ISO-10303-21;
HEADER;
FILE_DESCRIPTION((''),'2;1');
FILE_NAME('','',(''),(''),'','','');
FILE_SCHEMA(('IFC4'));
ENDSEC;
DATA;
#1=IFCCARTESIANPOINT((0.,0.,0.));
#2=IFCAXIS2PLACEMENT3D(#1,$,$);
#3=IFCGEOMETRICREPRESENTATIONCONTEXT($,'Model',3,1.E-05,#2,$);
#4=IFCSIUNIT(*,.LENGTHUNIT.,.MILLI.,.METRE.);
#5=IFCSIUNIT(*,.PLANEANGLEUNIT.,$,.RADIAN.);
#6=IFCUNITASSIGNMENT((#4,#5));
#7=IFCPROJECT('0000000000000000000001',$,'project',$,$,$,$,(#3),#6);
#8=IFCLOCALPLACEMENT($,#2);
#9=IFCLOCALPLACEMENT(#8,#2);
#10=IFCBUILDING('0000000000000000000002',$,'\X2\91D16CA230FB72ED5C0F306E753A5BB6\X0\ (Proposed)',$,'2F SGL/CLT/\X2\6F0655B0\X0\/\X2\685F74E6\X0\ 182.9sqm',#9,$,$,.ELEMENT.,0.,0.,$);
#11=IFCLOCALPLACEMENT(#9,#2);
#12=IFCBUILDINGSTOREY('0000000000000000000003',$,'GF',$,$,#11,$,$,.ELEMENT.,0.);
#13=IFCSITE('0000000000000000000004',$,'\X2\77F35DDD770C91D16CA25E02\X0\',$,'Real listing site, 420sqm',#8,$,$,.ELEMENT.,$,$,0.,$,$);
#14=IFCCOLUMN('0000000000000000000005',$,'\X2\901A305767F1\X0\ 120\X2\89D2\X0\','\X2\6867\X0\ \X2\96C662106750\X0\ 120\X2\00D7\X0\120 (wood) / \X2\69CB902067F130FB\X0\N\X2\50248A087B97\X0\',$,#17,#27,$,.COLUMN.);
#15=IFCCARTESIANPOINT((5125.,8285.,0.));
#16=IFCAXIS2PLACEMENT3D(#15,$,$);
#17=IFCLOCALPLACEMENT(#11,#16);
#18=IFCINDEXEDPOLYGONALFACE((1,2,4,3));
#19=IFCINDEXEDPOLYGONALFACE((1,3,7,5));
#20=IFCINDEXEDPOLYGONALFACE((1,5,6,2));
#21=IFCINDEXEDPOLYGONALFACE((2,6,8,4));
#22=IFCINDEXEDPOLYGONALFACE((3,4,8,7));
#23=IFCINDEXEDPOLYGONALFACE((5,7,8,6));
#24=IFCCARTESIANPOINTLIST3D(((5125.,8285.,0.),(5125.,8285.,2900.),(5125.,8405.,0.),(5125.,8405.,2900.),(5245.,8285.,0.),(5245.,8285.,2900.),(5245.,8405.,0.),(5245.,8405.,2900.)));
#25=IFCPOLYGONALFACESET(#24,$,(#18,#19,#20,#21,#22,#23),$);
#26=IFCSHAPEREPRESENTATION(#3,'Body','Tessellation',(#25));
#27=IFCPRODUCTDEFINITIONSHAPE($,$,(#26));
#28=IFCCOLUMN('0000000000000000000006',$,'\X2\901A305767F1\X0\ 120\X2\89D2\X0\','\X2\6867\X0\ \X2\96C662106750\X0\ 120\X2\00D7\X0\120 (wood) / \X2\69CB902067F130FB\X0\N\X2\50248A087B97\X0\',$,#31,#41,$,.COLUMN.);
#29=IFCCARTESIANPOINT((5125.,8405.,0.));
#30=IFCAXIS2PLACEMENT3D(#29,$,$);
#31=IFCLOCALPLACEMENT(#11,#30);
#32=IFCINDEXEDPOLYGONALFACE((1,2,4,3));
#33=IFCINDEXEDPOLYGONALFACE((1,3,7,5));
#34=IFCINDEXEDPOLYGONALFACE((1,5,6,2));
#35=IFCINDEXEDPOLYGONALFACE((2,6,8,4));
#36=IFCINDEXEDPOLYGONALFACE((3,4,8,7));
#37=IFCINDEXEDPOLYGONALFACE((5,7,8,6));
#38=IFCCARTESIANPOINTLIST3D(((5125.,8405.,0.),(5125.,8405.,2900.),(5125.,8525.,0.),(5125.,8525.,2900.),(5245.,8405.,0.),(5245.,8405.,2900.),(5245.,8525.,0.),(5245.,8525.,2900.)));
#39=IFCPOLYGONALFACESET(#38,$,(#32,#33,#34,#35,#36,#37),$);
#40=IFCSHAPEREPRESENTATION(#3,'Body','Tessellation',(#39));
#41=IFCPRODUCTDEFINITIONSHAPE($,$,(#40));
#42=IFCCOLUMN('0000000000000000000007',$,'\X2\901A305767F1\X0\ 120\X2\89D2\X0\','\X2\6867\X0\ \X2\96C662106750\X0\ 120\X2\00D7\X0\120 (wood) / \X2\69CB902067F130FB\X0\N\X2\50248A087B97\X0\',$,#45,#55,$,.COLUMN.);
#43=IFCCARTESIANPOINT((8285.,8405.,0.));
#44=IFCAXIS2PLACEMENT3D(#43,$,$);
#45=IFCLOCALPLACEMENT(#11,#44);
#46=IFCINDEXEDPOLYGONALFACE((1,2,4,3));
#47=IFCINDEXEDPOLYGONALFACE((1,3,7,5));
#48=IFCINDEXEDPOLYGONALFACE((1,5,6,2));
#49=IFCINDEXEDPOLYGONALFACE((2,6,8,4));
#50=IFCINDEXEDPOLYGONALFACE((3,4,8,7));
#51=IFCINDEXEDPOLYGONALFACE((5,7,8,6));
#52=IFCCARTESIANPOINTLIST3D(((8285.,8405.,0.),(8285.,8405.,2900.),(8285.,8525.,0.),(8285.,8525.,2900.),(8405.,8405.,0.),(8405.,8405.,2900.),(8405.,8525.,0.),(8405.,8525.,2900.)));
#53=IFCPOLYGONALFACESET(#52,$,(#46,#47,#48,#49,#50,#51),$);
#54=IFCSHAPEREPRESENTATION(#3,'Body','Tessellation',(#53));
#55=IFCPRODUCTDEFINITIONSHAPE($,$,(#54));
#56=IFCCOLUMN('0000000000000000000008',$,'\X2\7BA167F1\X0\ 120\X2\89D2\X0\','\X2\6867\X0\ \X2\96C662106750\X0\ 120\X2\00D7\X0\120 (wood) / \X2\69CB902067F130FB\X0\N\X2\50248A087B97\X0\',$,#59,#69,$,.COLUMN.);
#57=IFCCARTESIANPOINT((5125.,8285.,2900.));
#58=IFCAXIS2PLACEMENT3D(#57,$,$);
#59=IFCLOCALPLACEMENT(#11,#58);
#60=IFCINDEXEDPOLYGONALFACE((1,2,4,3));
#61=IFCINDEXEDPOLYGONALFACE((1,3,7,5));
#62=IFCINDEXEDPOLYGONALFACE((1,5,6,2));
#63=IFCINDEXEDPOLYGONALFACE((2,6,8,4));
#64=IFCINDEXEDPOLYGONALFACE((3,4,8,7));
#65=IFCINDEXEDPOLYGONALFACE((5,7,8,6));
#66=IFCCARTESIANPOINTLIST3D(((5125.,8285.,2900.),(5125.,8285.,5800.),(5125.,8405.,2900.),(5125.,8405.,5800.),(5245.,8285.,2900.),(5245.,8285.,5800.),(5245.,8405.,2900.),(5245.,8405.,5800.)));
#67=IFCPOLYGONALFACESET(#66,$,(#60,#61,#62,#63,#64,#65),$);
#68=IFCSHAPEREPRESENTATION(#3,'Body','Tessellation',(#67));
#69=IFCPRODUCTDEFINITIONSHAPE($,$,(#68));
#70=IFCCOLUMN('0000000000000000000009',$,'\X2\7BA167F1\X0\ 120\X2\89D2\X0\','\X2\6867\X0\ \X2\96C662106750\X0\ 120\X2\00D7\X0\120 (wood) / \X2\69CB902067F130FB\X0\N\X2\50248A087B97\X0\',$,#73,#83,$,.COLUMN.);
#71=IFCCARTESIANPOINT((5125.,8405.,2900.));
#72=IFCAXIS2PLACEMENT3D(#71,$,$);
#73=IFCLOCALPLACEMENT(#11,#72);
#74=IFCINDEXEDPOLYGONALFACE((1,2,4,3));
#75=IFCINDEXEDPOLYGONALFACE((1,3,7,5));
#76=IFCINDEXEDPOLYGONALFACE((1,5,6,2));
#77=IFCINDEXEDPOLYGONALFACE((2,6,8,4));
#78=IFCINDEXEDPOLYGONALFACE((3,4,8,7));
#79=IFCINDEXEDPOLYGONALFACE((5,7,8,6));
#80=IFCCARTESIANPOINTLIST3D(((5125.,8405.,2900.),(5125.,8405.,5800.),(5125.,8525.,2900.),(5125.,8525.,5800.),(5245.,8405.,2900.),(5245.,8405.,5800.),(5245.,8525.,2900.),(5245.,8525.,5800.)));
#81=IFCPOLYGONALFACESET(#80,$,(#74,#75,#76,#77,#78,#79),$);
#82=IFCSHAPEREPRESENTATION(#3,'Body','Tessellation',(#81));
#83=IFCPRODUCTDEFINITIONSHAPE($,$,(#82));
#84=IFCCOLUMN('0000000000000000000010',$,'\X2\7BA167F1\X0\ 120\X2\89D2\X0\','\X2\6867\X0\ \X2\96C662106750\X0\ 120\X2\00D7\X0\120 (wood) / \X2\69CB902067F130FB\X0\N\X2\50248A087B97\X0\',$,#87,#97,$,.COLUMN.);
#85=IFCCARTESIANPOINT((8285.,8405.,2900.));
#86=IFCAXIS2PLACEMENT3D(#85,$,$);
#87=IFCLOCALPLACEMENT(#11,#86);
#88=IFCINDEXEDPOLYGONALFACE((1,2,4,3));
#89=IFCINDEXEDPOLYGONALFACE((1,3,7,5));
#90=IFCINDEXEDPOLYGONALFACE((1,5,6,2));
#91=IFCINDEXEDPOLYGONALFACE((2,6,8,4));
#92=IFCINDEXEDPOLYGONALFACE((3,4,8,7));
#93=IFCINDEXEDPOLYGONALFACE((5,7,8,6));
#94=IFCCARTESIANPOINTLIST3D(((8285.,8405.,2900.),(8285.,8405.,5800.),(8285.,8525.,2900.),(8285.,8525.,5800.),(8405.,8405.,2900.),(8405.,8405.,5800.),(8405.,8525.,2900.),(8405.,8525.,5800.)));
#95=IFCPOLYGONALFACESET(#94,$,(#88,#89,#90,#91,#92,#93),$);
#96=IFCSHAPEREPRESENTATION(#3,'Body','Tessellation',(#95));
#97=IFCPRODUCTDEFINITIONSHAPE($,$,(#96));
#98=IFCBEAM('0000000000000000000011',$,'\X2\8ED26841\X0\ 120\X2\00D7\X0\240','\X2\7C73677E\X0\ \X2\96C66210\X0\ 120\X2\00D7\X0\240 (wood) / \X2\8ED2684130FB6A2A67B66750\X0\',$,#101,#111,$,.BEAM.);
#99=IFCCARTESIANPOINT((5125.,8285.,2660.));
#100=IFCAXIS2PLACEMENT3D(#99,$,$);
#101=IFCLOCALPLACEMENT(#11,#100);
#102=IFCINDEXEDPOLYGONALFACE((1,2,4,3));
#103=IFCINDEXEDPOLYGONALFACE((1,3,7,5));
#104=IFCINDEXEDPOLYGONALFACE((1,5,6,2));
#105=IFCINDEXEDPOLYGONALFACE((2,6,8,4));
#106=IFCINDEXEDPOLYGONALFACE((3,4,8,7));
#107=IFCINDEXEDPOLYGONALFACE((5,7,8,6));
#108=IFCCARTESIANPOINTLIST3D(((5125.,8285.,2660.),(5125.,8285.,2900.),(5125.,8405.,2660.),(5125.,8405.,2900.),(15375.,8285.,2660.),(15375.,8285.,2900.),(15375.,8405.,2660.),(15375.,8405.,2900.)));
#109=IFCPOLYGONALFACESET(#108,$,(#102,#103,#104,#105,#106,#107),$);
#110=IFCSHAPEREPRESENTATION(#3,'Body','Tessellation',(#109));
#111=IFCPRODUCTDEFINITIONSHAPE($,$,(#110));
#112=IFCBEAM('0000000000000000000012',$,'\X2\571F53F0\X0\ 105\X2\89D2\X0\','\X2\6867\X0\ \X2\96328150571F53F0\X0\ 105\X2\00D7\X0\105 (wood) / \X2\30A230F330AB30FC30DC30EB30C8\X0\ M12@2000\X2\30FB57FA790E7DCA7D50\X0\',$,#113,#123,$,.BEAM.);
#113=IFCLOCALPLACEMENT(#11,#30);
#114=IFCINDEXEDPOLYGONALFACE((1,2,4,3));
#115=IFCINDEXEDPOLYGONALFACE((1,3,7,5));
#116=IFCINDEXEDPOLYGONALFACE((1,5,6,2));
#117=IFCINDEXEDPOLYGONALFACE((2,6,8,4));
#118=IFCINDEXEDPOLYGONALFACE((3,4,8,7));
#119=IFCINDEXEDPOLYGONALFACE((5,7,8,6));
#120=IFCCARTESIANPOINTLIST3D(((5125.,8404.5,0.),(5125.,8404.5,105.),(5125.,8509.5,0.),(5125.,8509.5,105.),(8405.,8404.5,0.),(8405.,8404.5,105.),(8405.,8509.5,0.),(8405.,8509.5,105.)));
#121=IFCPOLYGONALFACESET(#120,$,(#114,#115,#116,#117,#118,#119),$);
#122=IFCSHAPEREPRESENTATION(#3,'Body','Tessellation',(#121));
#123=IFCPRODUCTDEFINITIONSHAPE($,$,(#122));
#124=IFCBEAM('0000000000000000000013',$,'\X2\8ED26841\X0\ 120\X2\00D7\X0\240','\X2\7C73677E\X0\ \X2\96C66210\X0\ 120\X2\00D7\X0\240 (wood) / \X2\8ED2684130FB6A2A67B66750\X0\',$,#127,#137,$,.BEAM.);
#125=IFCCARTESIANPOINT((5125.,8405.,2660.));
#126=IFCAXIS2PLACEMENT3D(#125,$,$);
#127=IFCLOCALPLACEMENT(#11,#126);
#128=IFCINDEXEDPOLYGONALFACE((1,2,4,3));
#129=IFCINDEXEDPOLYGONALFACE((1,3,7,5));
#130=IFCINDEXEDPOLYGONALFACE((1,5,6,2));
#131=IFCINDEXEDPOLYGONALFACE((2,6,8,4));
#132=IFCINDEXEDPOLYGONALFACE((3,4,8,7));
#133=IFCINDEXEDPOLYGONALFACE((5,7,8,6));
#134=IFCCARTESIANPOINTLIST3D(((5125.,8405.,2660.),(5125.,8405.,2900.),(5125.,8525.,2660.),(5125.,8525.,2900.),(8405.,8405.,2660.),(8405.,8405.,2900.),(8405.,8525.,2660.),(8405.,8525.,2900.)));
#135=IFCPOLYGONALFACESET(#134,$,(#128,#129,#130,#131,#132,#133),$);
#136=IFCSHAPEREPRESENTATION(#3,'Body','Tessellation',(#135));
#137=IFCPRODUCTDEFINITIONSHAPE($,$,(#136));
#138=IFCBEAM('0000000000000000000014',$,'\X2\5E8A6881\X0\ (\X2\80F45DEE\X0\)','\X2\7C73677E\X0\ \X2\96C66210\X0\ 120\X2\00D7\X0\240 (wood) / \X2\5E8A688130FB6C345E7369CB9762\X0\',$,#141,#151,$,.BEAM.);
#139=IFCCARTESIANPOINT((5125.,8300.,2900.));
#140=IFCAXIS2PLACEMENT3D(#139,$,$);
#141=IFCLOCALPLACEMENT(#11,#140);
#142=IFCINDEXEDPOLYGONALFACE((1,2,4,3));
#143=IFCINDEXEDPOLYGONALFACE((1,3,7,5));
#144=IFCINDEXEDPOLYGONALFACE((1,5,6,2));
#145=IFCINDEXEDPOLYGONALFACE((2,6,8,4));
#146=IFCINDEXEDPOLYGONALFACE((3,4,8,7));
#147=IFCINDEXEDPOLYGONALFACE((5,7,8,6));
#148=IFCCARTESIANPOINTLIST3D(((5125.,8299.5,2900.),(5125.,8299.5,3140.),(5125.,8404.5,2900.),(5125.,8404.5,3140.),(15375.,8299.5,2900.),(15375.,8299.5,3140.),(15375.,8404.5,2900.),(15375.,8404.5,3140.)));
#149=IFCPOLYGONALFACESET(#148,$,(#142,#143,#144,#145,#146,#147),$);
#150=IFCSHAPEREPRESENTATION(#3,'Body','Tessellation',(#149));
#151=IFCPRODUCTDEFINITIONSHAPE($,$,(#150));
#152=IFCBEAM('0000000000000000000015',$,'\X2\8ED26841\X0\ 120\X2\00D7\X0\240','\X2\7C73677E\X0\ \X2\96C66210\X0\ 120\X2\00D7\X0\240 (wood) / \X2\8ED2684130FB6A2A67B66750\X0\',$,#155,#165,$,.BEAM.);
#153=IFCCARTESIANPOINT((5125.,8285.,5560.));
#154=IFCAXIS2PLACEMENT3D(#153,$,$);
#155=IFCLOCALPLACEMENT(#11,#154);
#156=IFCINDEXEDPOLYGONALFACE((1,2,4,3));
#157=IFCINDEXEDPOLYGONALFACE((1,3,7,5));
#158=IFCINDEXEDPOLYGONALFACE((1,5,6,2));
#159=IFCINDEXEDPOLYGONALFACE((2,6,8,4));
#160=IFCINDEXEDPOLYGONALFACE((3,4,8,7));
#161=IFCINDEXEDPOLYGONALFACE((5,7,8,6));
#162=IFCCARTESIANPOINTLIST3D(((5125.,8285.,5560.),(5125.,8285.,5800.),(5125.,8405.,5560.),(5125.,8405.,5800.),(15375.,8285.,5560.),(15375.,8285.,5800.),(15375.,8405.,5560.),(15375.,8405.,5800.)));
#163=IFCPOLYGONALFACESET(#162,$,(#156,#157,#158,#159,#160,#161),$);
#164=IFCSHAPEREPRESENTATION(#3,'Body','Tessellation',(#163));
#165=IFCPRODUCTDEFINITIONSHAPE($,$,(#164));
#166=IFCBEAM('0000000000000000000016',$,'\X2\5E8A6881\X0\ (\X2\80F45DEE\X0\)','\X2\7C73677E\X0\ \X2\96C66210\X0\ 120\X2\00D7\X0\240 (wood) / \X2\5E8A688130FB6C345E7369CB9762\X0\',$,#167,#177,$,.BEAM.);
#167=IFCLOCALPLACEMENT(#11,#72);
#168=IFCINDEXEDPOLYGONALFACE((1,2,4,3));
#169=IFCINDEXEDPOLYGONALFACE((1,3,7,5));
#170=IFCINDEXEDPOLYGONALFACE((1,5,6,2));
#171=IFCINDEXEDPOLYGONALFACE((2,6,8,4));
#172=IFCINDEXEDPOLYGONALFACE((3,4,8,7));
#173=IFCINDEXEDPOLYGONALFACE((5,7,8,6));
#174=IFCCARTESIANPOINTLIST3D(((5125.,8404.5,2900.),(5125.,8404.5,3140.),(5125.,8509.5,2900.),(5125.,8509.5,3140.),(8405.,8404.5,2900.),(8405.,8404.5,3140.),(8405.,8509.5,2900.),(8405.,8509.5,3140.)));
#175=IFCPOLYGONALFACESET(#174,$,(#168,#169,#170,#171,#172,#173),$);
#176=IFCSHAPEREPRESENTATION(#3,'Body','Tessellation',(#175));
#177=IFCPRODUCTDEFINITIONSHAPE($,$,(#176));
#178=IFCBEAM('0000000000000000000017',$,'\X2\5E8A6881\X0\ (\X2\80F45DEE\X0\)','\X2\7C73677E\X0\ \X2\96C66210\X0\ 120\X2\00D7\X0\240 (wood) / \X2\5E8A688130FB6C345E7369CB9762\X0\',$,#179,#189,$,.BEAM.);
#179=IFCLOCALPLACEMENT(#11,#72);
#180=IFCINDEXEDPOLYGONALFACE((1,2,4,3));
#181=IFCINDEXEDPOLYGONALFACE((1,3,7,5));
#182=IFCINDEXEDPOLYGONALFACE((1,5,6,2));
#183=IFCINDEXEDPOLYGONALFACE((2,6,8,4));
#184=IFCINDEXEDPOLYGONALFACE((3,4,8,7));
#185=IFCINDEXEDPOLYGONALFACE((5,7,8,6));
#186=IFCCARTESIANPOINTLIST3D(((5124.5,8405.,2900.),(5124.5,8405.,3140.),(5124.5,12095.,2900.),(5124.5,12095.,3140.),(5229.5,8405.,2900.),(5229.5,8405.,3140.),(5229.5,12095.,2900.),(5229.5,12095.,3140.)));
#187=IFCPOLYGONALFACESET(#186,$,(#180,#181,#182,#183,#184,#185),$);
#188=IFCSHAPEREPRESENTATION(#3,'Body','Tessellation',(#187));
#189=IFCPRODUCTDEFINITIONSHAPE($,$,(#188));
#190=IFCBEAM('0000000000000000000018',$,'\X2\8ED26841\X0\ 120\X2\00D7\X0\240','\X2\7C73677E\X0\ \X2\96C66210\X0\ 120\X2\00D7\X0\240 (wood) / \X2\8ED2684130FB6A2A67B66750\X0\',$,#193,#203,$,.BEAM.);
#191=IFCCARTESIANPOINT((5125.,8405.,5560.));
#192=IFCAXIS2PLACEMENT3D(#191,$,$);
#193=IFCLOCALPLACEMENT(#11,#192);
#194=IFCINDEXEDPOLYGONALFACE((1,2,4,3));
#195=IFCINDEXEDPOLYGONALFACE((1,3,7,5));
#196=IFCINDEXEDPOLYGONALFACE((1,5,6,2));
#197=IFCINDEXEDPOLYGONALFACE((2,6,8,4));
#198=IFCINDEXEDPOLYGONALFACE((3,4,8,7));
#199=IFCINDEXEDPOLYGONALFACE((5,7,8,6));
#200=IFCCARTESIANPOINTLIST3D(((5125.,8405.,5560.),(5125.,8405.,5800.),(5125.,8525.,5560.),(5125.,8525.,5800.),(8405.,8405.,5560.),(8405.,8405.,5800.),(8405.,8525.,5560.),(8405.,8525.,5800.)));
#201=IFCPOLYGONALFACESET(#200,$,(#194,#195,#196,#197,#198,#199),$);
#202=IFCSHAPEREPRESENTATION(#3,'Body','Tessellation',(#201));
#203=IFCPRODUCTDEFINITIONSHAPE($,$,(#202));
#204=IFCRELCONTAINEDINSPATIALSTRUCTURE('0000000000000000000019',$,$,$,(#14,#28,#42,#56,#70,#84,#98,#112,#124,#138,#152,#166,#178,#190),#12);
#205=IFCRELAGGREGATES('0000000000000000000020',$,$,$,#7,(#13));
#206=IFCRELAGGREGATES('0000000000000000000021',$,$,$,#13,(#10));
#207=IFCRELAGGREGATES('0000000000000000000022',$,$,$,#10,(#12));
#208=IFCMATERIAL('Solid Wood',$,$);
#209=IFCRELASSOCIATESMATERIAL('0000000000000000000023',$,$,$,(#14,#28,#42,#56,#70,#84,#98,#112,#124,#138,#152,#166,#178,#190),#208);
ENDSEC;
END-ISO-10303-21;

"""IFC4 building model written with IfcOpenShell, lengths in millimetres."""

from ifc_helpers import new_model, si_unit, frame, frame_2d, origin, place, context, project, spatial, rectangle, extrude, material, element, save


model = new_model("IFC4")

# Units and contexts
model_context = context("Model", 3, precision=1e-05, world=origin())
ifc_project = project(units=[si_unit("LENGTHUNIT", "METRE", prefix="MILLI"), si_unit("PLANEANGLEUNIT", "RADIAN")], contexts=[model_context])

# Site, building, storey
site_placement = place(None, origin())
site = spatial("IfcSite", under=ifc_project, at=site_placement, Name="石川県金沢市", ObjectType="Real listing site, 420sqm", CompositionType="ELEMENT", RefElevation=0.0)
building_placement = place(site_placement, origin())
building = spatial("IfcBuilding", under=site, at=building_placement, Name="金沢・狭小の町家 (Proposed)", ObjectType="2F SGL/CLT/漆喰/桟瓦 182.9sqm", CompositionType="ELEMENT", ElevationOfRefHeight=0.0, ElevationOfTerrain=0.0)
storey_placement = place(building_placement, origin())
storey = spatial("IfcBuildingStorey", under=building, at=storey_placement, Name="GF", CompositionType="ELEMENT", Elevation=0.0)

# Columns
ifc_material_1 = material(Name="Solid Wood")
column_1_placement = place(storey_placement, frame((5125.0, 8285.0, 0.0)))
element("IfcColumn", 1, at=column_1_placement, inside=storey, material=ifc_material_1, Name="通し柱 120角", Description="桧 集成材 120×120 (wood) / 構造柱・N値計算", PredefinedType="COLUMN", context=model_context, shape_type="SweptSolid", body=[
    extrude(rectangle(XDim=120.0, YDim=120.0, at=frame_2d((60.0, 60.0))), frame((5125.0, 8285.0, 0.0)), (0.0, 0.0, 1.0), 2900.0),
])
column_2_placement = place(storey_placement, frame((5125.0, 8405.0, 0.0)))
element("IfcColumn", 2, at=column_2_placement, inside=storey, material=ifc_material_1, Name="通し柱 120角", Description="桧 集成材 120×120 (wood) / 構造柱・N値計算", PredefinedType="COLUMN", context=model_context, shape_type="SweptSolid", body=[
    extrude(rectangle(XDim=120.0, YDim=120.0, at=frame_2d((60.0, 60.0))), frame((5125.0, 8405.0, 0.0)), (0.0, 0.0, 1.0), 2900.0),
])
column_3_placement = place(storey_placement, frame((8285.0, 8405.0, 0.0)))
element("IfcColumn", 3, at=column_3_placement, inside=storey, material=ifc_material_1, Name="通し柱 120角", Description="桧 集成材 120×120 (wood) / 構造柱・N値計算", PredefinedType="COLUMN", context=model_context, shape_type="SweptSolid", body=[
    extrude(rectangle(XDim=120.0, YDim=120.0, at=frame_2d((60.0, 60.0))), frame((8285.0, 8405.0, 0.0)), (0.0, 0.0, 1.0), 2900.0),
])
column_4_placement = place(storey_placement, frame((5125.0, 8285.0, 2900.0)))
element("IfcColumn", 4, at=column_4_placement, inside=storey, material=ifc_material_1, Name="管柱 120角", Description="桧 集成材 120×120 (wood) / 構造柱・N値計算", PredefinedType="COLUMN", context=model_context, shape_type="SweptSolid", body=[
    extrude(rectangle(XDim=120.0, YDim=120.0, at=frame_2d((60.0, 60.0))), frame((5125.0, 8285.0, 2900.0)), (0.0, 0.0, 1.0), 2900.0),
])
column_5_placement = place(storey_placement, frame((5125.0, 8405.0, 2900.0)))
element("IfcColumn", 5, at=column_5_placement, inside=storey, material=ifc_material_1, Name="管柱 120角", Description="桧 集成材 120×120 (wood) / 構造柱・N値計算", PredefinedType="COLUMN", context=model_context, shape_type="SweptSolid", body=[
    extrude(rectangle(XDim=120.0, YDim=120.0, at=frame_2d((60.0, 60.0))), frame((5125.0, 8405.0, 2900.0)), (0.0, 0.0, 1.0), 2900.0),
])
column_6_placement = place(storey_placement, frame((8285.0, 8405.0, 2900.0)))
element("IfcColumn", 6, at=column_6_placement, inside=storey, material=ifc_material_1, Name="管柱 120角", Description="桧 集成材 120×120 (wood) / 構造柱・N値計算", PredefinedType="COLUMN", context=model_context, shape_type="SweptSolid", body=[
    extrude(rectangle(XDim=120.0, YDim=120.0, at=frame_2d((60.0, 60.0))), frame((8285.0, 8405.0, 2900.0)), (0.0, 0.0, 1.0), 2900.0),
])

# Beams
beam_1_placement = place(storey_placement, frame((5125.0, 8285.0, 2660.0)))
element("IfcBeam", 7, at=beam_1_placement, inside=storey, material=ifc_material_1, Name="軒桁 120×240", Description="米松 集成 120×240 (wood) / 軒桁・横架材", PredefinedType="BEAM", context=model_context, shape_type="SweptSolid", body=[
    extrude(rectangle(XDim=10250.0, YDim=120.0, at=frame_2d((5125.0, 60.0))), frame((5125.0, 8285.0, 2660.0)), (0.0, 0.0, 1.0), 240.0),
])
beam_2_placement = place(storey_placement, frame((5125.0, 8405.0, 0.0)))
element("IfcBeam", 8, at=beam_2_placement, inside=storey, material=ifc_material_1, Name="土台 105角", Description="桧 防腐土台 105×105 (wood) / アンカーボルト M12@2000・基礎緊結", PredefinedType="BEAM", context=model_context, shape_type="SweptSolid", body=[
    extrude(rectangle(XDim=3280.0, YDim=105.0, at=frame_2d((1640.0, 52.0))), frame((5125.0, 8405.0, 0.0)), (0.0, 0.0, 1.0), 105.0),
])
beam_3_placement = place(storey_placement, frame((5125.0, 8405.0, 2660.0)))
element("IfcBeam", 9, at=beam_3_placement, inside=storey, material=ifc_material_1, Name="軒桁 120×240", Description="米松 集成 120×240 (wood) / 軒桁・横架材", PredefinedType="BEAM", context=model_context, shape_type="SweptSolid", body=[
    extrude(rectangle(XDim=3280.0, YDim=120.0, at=frame_2d((1640.0, 60.0))), frame((5125.0, 8405.0, 2660.0)), (0.0, 0.0, 1.0), 240.0),
])
beam_4_placement = place(storey_placement, frame((5125.0, 8300.0, 2900.0)))
element("IfcBeam", 10, at=beam_4_placement, inside=storey, material=ifc_material_1, Name="床梁 (胴差)", Description="米松 集成 120×240 (wood) / 床梁・水平構面", PredefinedType="BEAM", context=model_context, shape_type="SweptSolid", body=[
    extrude(rectangle(XDim=10250.0, YDim=105.0, at=frame_2d((5125.0, 52.0))), frame((5125.0, 8300.0, 2900.0)), (0.0, 0.0, 1.0), 240.0),
])
beam_5_placement = place(storey_placement, frame((5125.0, 8285.0, 5560.0)))
element("IfcBeam", 11, at=beam_5_placement, inside=storey, material=ifc_material_1, Name="軒桁 120×240", Description="米松 集成 120×240 (wood) / 軒桁・横架材", PredefinedType="BEAM", context=model_context, shape_type="SweptSolid", body=[
    extrude(rectangle(XDim=10250.0, YDim=120.0, at=frame_2d((5125.0, 60.0))), frame((5125.0, 8285.0, 5560.0)), (0.0, 0.0, 1.0), 240.0),
])
beam_6_placement = place(storey_placement, frame((5125.0, 8405.0, 2900.0)))
element("IfcBeam", 12, at=beam_6_placement, inside=storey, material=ifc_material_1, Name="床梁 (胴差)", Description="米松 集成 120×240 (wood) / 床梁・水平構面", PredefinedType="BEAM", context=model_context, shape_type="SweptSolid", body=[
    extrude(rectangle(XDim=3280.0, YDim=105.0, at=frame_2d((1640.0, 52.0))), frame((5125.0, 8405.0, 2900.0)), (0.0, 0.0, 1.0), 240.0),
])
beam_7_placement = place(storey_placement, frame((5125.0, 8405.0, 2900.0)))
element("IfcBeam", 13, at=beam_7_placement, inside=storey, material=ifc_material_1, Name="床梁 (胴差)", Description="米松 集成 120×240 (wood) / 床梁・水平構面", PredefinedType="BEAM", context=model_context, shape_type="SweptSolid", body=[
    extrude(rectangle(XDim=105.0, YDim=3690.0, at=frame_2d((52.0, 1845.0))), frame((5125.0, 8405.0, 2900.0)), (0.0, 0.0, 1.0), 240.0),
])
beam_8_placement = place(storey_placement, frame((5125.0, 8405.0, 5560.0)))
element("IfcBeam", 14, at=beam_8_placement, inside=storey, material=ifc_material_1, Name="軒桁 120×240", Description="米松 集成 120×240 (wood) / 軒桁・横架材", PredefinedType="BEAM", context=model_context, shape_type="SweptSolid", body=[
    extrude(rectangle(XDim=3280.0, YDim=120.0, at=frame_2d((1640.0, 60.0))), frame((5125.0, 8405.0, 5560.0)), (0.0, 0.0, 1.0), 240.0),
])

save(model, "model.ifc")
